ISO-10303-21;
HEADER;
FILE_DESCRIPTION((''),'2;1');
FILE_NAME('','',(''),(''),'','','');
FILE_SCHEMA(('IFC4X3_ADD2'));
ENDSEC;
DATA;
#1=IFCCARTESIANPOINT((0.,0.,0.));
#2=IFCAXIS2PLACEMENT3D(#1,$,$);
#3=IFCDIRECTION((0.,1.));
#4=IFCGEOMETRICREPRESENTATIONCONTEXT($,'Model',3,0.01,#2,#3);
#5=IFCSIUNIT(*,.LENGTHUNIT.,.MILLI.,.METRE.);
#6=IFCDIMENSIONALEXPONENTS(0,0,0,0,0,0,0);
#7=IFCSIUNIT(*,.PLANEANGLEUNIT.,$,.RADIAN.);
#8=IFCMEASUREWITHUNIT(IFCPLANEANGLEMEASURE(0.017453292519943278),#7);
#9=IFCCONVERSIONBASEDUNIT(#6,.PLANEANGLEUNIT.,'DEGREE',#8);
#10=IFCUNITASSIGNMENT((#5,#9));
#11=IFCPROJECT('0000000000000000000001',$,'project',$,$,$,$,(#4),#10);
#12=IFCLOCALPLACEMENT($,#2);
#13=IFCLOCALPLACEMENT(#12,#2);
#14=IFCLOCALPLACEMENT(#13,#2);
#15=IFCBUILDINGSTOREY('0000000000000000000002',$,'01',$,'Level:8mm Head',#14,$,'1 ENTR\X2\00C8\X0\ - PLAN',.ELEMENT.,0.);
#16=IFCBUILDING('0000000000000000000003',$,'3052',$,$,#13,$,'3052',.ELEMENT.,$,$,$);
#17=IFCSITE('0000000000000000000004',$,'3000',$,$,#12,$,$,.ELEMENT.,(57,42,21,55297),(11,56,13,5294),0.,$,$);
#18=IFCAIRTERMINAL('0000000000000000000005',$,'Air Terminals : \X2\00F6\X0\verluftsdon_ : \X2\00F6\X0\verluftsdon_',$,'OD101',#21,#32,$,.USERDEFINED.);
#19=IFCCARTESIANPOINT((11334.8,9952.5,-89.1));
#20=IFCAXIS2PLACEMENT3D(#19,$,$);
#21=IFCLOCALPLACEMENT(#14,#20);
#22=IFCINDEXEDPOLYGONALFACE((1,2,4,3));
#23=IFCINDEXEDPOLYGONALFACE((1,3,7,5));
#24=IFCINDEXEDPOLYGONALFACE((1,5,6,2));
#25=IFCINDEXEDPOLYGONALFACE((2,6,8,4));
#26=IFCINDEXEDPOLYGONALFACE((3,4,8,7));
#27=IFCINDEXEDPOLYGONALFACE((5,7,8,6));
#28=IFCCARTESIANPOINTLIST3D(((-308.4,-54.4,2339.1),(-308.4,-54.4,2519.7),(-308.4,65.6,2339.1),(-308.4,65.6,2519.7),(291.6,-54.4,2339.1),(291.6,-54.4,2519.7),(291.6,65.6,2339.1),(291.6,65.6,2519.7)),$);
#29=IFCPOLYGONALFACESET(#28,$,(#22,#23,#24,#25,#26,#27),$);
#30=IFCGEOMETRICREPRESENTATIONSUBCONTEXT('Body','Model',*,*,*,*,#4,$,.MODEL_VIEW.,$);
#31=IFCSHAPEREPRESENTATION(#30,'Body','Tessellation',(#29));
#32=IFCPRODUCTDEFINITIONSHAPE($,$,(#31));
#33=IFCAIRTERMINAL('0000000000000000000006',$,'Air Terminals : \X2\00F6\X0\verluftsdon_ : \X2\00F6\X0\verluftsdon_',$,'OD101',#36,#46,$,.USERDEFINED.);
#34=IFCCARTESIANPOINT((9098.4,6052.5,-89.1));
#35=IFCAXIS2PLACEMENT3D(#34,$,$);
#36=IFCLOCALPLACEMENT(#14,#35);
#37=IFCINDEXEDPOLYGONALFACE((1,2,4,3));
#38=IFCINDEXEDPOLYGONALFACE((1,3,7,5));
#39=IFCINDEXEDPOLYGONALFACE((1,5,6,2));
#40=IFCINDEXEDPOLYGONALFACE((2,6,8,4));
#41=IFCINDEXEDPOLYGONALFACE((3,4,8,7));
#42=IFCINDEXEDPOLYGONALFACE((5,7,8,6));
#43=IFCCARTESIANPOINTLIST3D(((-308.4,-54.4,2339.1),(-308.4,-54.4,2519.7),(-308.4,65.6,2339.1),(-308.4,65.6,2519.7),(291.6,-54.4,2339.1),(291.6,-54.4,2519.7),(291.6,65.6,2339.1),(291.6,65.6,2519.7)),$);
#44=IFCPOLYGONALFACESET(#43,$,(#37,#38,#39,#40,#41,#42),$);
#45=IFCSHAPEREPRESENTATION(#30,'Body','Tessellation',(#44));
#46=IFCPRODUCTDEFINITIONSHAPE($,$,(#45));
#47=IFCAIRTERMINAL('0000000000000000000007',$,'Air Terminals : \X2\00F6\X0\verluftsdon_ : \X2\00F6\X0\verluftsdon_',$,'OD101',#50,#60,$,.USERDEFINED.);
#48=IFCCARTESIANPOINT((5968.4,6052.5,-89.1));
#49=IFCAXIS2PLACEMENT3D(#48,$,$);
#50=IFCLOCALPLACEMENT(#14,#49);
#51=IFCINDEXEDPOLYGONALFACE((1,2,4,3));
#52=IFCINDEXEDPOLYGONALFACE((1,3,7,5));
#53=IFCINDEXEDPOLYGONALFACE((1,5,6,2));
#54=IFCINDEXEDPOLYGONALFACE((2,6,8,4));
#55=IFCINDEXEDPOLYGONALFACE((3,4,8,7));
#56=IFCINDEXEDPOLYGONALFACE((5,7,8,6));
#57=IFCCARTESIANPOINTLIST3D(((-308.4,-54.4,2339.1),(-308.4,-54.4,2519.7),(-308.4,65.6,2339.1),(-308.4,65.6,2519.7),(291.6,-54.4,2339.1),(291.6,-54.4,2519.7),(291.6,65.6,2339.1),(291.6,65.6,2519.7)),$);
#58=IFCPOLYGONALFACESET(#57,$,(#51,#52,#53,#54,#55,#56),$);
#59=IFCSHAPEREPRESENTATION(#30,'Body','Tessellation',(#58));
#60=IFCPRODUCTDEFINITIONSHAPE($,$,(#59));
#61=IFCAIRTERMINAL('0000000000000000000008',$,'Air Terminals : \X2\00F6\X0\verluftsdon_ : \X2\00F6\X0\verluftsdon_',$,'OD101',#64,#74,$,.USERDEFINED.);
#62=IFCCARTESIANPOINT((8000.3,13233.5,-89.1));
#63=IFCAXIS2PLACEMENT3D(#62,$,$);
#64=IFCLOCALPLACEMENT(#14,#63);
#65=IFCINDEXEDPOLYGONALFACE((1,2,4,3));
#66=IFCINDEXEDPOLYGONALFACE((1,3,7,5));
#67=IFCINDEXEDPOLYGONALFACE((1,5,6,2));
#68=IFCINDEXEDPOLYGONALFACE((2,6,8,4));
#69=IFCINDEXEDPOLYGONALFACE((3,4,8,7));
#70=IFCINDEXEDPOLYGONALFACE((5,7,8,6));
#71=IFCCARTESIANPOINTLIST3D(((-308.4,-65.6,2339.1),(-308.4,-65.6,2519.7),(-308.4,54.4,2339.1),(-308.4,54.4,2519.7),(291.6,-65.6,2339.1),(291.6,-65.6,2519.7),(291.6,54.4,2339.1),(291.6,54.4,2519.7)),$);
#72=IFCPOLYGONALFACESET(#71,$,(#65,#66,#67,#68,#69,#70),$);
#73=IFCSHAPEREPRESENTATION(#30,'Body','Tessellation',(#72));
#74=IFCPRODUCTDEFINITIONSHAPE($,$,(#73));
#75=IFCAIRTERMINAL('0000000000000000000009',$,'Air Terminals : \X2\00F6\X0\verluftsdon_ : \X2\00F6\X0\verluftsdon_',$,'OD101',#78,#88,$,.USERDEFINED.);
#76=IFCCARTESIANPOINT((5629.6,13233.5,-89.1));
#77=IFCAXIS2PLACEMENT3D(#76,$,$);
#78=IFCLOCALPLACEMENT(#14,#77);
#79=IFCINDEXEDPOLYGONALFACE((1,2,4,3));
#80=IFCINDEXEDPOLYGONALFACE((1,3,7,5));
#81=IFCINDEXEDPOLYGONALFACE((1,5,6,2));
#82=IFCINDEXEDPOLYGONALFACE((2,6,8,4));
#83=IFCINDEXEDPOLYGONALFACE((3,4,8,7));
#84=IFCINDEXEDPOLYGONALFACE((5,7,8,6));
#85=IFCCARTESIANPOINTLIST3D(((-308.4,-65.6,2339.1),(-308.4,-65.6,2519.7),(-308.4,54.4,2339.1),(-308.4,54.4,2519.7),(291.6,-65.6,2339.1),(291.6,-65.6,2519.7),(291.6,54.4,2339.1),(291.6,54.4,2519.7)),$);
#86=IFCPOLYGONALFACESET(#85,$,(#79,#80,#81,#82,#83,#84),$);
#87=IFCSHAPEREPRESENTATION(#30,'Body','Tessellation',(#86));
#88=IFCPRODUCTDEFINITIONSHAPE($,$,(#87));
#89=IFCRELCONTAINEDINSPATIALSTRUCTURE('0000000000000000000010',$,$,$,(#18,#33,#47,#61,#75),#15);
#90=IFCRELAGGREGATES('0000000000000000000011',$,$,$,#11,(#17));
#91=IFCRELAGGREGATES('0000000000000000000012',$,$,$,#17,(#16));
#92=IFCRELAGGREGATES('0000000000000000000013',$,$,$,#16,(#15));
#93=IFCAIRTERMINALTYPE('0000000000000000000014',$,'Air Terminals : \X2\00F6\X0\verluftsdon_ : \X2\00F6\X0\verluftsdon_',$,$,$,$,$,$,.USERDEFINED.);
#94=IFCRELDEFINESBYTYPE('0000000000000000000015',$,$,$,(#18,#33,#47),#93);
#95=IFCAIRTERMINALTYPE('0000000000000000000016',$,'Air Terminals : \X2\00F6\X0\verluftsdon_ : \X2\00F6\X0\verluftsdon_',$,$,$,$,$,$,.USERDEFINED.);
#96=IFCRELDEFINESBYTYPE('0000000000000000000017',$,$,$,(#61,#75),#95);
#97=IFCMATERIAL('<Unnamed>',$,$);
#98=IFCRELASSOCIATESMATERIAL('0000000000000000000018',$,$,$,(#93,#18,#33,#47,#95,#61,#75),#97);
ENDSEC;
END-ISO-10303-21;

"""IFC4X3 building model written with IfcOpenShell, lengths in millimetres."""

from ifc_helpers import new_model, entity, si_unit, converted_unit, direction, frame, origin, origin_2d_with_axis, place, context, subcontext, project, spatial, rectangle, extrude, source, transform, mapped, material, type_object, type_shapes, element, save


model = new_model("IFC4X3")

# Units and contexts
model_context = context("Model", 3, precision=0.01, world=origin(), true_north=direction((0.0, 1.0)))
body_context = subcontext(model_context, "Body", "Model", "MODEL_VIEW")
ifc_project = project(units=[si_unit("LENGTHUNIT", "METRE", prefix="MILLI"), converted_unit("PLANEANGLEUNIT", "DEGREE", entity("IfcPlaneAngleMeasure", 0.017453292519943278), si_unit("PLANEANGLEUNIT", "RADIAN"), dimensions=[0, 0, 0, 0, 0, 0, 0])], contexts=[model_context])

# Site, building, storey
site_placement = place(None, origin())
site = spatial("IfcSite", under=ifc_project, at=site_placement, Name="3000", CompositionType="ELEMENT", RefLatitude=(57, 42, 21, 55297), RefLongitude=(11, 56, 13, 5294), RefElevation=0.0)
building_placement = place(site_placement, origin())
building = spatial("IfcBuilding", under=site, at=building_placement, Name="3052", LongName="3052", CompositionType="ELEMENT")
storey_placement = place(building_placement, origin())
storey = spatial("IfcBuildingStorey", under=building, at=storey_placement, Name="01", ObjectType="Level:8mm Head", LongName="1 ENTRÈ - PLAN", CompositionType="ELEMENT", Elevation=0.0)

# Air terminals
ifc_material_1 = material(Name="<Unnamed>")
air_terminal_type_1 = type_object("IfcAirTerminalType", Name="Air Terminals : överluftsdon_ : överluftsdon_", PredefinedType="USERDEFINED", material=ifc_material_1)
shared_shape_1 = source(origin(), body_context, "Body", "SweptSolid", [
    extrude(rectangle(XDim=600.0, YDim=120.0, at=origin_2d_with_axis()), frame((-8.4, 5.6, 2339.1), z_axis=(0.0, 0.0, 1.0), x_axis=(-1.0, 0.0, 0.0)), (0.0, 0.0, 1.0), 180.7),
])
type_shapes(air_terminal_type_1, [shared_shape_1])
for number, where, name in (
    (1, (11334.8, 9952.5, -89.1), "Air Terminals : överluftsdon_ : överluftsdon_"),
    (2, (9098.4, 6052.5, -89.1), "Air Terminals : överluftsdon_ : överluftsdon_"),
    (3, (5968.4, 6052.5, -89.1), "Air Terminals : överluftsdon_ : överluftsdon_"),
):
    element("IfcAirTerminal", number, at=place(storey_placement, frame(where)), inside=storey, type_object=air_terminal_type_1, material=ifc_material_1, Name=name, ObjectType="OD101", PredefinedType="USERDEFINED", context=body_context, shape_type="MappedRepresentation", body=[
        mapped(shared_shape_1, transform((0.0, 0.0, 0.0), scale=1.0)),
    ])
air_terminal_type_2 = type_object("IfcAirTerminalType", Name="Air Terminals : överluftsdon_ : överluftsdon_", PredefinedType="USERDEFINED", material=ifc_material_1)
shared_shape_2 = source(origin(), body_context, "Body", "SweptSolid", [
    extrude(rectangle(XDim=120.0, YDim=600.0, at=origin_2d_with_axis()), frame((-8.4, -5.6, 2339.1), z_axis=(0.0, 0.0, 1.0), x_axis=(0.0, 1.0, 0.0)), (0.0, 0.0, 1.0), 180.7),
])
type_shapes(air_terminal_type_2, [shared_shape_2])
for number, where, name in (
    (4, (8000.3, 13233.5, -89.1), "Air Terminals : överluftsdon_ : överluftsdon_"),
    (5, (5629.6, 13233.5, -89.1), "Air Terminals : överluftsdon_ : överluftsdon_"),
):
    element("IfcAirTerminal", number, at=place(storey_placement, frame(where)), inside=storey, type_object=air_terminal_type_2, material=ifc_material_1, Name=name, ObjectType="OD101", PredefinedType="USERDEFINED", context=body_context, shape_type="MappedRepresentation", body=[
        mapped(shared_shape_2, transform((0.0, 0.0, 0.0), scale=1.0)),
    ])

save(model, "model.ifc")
